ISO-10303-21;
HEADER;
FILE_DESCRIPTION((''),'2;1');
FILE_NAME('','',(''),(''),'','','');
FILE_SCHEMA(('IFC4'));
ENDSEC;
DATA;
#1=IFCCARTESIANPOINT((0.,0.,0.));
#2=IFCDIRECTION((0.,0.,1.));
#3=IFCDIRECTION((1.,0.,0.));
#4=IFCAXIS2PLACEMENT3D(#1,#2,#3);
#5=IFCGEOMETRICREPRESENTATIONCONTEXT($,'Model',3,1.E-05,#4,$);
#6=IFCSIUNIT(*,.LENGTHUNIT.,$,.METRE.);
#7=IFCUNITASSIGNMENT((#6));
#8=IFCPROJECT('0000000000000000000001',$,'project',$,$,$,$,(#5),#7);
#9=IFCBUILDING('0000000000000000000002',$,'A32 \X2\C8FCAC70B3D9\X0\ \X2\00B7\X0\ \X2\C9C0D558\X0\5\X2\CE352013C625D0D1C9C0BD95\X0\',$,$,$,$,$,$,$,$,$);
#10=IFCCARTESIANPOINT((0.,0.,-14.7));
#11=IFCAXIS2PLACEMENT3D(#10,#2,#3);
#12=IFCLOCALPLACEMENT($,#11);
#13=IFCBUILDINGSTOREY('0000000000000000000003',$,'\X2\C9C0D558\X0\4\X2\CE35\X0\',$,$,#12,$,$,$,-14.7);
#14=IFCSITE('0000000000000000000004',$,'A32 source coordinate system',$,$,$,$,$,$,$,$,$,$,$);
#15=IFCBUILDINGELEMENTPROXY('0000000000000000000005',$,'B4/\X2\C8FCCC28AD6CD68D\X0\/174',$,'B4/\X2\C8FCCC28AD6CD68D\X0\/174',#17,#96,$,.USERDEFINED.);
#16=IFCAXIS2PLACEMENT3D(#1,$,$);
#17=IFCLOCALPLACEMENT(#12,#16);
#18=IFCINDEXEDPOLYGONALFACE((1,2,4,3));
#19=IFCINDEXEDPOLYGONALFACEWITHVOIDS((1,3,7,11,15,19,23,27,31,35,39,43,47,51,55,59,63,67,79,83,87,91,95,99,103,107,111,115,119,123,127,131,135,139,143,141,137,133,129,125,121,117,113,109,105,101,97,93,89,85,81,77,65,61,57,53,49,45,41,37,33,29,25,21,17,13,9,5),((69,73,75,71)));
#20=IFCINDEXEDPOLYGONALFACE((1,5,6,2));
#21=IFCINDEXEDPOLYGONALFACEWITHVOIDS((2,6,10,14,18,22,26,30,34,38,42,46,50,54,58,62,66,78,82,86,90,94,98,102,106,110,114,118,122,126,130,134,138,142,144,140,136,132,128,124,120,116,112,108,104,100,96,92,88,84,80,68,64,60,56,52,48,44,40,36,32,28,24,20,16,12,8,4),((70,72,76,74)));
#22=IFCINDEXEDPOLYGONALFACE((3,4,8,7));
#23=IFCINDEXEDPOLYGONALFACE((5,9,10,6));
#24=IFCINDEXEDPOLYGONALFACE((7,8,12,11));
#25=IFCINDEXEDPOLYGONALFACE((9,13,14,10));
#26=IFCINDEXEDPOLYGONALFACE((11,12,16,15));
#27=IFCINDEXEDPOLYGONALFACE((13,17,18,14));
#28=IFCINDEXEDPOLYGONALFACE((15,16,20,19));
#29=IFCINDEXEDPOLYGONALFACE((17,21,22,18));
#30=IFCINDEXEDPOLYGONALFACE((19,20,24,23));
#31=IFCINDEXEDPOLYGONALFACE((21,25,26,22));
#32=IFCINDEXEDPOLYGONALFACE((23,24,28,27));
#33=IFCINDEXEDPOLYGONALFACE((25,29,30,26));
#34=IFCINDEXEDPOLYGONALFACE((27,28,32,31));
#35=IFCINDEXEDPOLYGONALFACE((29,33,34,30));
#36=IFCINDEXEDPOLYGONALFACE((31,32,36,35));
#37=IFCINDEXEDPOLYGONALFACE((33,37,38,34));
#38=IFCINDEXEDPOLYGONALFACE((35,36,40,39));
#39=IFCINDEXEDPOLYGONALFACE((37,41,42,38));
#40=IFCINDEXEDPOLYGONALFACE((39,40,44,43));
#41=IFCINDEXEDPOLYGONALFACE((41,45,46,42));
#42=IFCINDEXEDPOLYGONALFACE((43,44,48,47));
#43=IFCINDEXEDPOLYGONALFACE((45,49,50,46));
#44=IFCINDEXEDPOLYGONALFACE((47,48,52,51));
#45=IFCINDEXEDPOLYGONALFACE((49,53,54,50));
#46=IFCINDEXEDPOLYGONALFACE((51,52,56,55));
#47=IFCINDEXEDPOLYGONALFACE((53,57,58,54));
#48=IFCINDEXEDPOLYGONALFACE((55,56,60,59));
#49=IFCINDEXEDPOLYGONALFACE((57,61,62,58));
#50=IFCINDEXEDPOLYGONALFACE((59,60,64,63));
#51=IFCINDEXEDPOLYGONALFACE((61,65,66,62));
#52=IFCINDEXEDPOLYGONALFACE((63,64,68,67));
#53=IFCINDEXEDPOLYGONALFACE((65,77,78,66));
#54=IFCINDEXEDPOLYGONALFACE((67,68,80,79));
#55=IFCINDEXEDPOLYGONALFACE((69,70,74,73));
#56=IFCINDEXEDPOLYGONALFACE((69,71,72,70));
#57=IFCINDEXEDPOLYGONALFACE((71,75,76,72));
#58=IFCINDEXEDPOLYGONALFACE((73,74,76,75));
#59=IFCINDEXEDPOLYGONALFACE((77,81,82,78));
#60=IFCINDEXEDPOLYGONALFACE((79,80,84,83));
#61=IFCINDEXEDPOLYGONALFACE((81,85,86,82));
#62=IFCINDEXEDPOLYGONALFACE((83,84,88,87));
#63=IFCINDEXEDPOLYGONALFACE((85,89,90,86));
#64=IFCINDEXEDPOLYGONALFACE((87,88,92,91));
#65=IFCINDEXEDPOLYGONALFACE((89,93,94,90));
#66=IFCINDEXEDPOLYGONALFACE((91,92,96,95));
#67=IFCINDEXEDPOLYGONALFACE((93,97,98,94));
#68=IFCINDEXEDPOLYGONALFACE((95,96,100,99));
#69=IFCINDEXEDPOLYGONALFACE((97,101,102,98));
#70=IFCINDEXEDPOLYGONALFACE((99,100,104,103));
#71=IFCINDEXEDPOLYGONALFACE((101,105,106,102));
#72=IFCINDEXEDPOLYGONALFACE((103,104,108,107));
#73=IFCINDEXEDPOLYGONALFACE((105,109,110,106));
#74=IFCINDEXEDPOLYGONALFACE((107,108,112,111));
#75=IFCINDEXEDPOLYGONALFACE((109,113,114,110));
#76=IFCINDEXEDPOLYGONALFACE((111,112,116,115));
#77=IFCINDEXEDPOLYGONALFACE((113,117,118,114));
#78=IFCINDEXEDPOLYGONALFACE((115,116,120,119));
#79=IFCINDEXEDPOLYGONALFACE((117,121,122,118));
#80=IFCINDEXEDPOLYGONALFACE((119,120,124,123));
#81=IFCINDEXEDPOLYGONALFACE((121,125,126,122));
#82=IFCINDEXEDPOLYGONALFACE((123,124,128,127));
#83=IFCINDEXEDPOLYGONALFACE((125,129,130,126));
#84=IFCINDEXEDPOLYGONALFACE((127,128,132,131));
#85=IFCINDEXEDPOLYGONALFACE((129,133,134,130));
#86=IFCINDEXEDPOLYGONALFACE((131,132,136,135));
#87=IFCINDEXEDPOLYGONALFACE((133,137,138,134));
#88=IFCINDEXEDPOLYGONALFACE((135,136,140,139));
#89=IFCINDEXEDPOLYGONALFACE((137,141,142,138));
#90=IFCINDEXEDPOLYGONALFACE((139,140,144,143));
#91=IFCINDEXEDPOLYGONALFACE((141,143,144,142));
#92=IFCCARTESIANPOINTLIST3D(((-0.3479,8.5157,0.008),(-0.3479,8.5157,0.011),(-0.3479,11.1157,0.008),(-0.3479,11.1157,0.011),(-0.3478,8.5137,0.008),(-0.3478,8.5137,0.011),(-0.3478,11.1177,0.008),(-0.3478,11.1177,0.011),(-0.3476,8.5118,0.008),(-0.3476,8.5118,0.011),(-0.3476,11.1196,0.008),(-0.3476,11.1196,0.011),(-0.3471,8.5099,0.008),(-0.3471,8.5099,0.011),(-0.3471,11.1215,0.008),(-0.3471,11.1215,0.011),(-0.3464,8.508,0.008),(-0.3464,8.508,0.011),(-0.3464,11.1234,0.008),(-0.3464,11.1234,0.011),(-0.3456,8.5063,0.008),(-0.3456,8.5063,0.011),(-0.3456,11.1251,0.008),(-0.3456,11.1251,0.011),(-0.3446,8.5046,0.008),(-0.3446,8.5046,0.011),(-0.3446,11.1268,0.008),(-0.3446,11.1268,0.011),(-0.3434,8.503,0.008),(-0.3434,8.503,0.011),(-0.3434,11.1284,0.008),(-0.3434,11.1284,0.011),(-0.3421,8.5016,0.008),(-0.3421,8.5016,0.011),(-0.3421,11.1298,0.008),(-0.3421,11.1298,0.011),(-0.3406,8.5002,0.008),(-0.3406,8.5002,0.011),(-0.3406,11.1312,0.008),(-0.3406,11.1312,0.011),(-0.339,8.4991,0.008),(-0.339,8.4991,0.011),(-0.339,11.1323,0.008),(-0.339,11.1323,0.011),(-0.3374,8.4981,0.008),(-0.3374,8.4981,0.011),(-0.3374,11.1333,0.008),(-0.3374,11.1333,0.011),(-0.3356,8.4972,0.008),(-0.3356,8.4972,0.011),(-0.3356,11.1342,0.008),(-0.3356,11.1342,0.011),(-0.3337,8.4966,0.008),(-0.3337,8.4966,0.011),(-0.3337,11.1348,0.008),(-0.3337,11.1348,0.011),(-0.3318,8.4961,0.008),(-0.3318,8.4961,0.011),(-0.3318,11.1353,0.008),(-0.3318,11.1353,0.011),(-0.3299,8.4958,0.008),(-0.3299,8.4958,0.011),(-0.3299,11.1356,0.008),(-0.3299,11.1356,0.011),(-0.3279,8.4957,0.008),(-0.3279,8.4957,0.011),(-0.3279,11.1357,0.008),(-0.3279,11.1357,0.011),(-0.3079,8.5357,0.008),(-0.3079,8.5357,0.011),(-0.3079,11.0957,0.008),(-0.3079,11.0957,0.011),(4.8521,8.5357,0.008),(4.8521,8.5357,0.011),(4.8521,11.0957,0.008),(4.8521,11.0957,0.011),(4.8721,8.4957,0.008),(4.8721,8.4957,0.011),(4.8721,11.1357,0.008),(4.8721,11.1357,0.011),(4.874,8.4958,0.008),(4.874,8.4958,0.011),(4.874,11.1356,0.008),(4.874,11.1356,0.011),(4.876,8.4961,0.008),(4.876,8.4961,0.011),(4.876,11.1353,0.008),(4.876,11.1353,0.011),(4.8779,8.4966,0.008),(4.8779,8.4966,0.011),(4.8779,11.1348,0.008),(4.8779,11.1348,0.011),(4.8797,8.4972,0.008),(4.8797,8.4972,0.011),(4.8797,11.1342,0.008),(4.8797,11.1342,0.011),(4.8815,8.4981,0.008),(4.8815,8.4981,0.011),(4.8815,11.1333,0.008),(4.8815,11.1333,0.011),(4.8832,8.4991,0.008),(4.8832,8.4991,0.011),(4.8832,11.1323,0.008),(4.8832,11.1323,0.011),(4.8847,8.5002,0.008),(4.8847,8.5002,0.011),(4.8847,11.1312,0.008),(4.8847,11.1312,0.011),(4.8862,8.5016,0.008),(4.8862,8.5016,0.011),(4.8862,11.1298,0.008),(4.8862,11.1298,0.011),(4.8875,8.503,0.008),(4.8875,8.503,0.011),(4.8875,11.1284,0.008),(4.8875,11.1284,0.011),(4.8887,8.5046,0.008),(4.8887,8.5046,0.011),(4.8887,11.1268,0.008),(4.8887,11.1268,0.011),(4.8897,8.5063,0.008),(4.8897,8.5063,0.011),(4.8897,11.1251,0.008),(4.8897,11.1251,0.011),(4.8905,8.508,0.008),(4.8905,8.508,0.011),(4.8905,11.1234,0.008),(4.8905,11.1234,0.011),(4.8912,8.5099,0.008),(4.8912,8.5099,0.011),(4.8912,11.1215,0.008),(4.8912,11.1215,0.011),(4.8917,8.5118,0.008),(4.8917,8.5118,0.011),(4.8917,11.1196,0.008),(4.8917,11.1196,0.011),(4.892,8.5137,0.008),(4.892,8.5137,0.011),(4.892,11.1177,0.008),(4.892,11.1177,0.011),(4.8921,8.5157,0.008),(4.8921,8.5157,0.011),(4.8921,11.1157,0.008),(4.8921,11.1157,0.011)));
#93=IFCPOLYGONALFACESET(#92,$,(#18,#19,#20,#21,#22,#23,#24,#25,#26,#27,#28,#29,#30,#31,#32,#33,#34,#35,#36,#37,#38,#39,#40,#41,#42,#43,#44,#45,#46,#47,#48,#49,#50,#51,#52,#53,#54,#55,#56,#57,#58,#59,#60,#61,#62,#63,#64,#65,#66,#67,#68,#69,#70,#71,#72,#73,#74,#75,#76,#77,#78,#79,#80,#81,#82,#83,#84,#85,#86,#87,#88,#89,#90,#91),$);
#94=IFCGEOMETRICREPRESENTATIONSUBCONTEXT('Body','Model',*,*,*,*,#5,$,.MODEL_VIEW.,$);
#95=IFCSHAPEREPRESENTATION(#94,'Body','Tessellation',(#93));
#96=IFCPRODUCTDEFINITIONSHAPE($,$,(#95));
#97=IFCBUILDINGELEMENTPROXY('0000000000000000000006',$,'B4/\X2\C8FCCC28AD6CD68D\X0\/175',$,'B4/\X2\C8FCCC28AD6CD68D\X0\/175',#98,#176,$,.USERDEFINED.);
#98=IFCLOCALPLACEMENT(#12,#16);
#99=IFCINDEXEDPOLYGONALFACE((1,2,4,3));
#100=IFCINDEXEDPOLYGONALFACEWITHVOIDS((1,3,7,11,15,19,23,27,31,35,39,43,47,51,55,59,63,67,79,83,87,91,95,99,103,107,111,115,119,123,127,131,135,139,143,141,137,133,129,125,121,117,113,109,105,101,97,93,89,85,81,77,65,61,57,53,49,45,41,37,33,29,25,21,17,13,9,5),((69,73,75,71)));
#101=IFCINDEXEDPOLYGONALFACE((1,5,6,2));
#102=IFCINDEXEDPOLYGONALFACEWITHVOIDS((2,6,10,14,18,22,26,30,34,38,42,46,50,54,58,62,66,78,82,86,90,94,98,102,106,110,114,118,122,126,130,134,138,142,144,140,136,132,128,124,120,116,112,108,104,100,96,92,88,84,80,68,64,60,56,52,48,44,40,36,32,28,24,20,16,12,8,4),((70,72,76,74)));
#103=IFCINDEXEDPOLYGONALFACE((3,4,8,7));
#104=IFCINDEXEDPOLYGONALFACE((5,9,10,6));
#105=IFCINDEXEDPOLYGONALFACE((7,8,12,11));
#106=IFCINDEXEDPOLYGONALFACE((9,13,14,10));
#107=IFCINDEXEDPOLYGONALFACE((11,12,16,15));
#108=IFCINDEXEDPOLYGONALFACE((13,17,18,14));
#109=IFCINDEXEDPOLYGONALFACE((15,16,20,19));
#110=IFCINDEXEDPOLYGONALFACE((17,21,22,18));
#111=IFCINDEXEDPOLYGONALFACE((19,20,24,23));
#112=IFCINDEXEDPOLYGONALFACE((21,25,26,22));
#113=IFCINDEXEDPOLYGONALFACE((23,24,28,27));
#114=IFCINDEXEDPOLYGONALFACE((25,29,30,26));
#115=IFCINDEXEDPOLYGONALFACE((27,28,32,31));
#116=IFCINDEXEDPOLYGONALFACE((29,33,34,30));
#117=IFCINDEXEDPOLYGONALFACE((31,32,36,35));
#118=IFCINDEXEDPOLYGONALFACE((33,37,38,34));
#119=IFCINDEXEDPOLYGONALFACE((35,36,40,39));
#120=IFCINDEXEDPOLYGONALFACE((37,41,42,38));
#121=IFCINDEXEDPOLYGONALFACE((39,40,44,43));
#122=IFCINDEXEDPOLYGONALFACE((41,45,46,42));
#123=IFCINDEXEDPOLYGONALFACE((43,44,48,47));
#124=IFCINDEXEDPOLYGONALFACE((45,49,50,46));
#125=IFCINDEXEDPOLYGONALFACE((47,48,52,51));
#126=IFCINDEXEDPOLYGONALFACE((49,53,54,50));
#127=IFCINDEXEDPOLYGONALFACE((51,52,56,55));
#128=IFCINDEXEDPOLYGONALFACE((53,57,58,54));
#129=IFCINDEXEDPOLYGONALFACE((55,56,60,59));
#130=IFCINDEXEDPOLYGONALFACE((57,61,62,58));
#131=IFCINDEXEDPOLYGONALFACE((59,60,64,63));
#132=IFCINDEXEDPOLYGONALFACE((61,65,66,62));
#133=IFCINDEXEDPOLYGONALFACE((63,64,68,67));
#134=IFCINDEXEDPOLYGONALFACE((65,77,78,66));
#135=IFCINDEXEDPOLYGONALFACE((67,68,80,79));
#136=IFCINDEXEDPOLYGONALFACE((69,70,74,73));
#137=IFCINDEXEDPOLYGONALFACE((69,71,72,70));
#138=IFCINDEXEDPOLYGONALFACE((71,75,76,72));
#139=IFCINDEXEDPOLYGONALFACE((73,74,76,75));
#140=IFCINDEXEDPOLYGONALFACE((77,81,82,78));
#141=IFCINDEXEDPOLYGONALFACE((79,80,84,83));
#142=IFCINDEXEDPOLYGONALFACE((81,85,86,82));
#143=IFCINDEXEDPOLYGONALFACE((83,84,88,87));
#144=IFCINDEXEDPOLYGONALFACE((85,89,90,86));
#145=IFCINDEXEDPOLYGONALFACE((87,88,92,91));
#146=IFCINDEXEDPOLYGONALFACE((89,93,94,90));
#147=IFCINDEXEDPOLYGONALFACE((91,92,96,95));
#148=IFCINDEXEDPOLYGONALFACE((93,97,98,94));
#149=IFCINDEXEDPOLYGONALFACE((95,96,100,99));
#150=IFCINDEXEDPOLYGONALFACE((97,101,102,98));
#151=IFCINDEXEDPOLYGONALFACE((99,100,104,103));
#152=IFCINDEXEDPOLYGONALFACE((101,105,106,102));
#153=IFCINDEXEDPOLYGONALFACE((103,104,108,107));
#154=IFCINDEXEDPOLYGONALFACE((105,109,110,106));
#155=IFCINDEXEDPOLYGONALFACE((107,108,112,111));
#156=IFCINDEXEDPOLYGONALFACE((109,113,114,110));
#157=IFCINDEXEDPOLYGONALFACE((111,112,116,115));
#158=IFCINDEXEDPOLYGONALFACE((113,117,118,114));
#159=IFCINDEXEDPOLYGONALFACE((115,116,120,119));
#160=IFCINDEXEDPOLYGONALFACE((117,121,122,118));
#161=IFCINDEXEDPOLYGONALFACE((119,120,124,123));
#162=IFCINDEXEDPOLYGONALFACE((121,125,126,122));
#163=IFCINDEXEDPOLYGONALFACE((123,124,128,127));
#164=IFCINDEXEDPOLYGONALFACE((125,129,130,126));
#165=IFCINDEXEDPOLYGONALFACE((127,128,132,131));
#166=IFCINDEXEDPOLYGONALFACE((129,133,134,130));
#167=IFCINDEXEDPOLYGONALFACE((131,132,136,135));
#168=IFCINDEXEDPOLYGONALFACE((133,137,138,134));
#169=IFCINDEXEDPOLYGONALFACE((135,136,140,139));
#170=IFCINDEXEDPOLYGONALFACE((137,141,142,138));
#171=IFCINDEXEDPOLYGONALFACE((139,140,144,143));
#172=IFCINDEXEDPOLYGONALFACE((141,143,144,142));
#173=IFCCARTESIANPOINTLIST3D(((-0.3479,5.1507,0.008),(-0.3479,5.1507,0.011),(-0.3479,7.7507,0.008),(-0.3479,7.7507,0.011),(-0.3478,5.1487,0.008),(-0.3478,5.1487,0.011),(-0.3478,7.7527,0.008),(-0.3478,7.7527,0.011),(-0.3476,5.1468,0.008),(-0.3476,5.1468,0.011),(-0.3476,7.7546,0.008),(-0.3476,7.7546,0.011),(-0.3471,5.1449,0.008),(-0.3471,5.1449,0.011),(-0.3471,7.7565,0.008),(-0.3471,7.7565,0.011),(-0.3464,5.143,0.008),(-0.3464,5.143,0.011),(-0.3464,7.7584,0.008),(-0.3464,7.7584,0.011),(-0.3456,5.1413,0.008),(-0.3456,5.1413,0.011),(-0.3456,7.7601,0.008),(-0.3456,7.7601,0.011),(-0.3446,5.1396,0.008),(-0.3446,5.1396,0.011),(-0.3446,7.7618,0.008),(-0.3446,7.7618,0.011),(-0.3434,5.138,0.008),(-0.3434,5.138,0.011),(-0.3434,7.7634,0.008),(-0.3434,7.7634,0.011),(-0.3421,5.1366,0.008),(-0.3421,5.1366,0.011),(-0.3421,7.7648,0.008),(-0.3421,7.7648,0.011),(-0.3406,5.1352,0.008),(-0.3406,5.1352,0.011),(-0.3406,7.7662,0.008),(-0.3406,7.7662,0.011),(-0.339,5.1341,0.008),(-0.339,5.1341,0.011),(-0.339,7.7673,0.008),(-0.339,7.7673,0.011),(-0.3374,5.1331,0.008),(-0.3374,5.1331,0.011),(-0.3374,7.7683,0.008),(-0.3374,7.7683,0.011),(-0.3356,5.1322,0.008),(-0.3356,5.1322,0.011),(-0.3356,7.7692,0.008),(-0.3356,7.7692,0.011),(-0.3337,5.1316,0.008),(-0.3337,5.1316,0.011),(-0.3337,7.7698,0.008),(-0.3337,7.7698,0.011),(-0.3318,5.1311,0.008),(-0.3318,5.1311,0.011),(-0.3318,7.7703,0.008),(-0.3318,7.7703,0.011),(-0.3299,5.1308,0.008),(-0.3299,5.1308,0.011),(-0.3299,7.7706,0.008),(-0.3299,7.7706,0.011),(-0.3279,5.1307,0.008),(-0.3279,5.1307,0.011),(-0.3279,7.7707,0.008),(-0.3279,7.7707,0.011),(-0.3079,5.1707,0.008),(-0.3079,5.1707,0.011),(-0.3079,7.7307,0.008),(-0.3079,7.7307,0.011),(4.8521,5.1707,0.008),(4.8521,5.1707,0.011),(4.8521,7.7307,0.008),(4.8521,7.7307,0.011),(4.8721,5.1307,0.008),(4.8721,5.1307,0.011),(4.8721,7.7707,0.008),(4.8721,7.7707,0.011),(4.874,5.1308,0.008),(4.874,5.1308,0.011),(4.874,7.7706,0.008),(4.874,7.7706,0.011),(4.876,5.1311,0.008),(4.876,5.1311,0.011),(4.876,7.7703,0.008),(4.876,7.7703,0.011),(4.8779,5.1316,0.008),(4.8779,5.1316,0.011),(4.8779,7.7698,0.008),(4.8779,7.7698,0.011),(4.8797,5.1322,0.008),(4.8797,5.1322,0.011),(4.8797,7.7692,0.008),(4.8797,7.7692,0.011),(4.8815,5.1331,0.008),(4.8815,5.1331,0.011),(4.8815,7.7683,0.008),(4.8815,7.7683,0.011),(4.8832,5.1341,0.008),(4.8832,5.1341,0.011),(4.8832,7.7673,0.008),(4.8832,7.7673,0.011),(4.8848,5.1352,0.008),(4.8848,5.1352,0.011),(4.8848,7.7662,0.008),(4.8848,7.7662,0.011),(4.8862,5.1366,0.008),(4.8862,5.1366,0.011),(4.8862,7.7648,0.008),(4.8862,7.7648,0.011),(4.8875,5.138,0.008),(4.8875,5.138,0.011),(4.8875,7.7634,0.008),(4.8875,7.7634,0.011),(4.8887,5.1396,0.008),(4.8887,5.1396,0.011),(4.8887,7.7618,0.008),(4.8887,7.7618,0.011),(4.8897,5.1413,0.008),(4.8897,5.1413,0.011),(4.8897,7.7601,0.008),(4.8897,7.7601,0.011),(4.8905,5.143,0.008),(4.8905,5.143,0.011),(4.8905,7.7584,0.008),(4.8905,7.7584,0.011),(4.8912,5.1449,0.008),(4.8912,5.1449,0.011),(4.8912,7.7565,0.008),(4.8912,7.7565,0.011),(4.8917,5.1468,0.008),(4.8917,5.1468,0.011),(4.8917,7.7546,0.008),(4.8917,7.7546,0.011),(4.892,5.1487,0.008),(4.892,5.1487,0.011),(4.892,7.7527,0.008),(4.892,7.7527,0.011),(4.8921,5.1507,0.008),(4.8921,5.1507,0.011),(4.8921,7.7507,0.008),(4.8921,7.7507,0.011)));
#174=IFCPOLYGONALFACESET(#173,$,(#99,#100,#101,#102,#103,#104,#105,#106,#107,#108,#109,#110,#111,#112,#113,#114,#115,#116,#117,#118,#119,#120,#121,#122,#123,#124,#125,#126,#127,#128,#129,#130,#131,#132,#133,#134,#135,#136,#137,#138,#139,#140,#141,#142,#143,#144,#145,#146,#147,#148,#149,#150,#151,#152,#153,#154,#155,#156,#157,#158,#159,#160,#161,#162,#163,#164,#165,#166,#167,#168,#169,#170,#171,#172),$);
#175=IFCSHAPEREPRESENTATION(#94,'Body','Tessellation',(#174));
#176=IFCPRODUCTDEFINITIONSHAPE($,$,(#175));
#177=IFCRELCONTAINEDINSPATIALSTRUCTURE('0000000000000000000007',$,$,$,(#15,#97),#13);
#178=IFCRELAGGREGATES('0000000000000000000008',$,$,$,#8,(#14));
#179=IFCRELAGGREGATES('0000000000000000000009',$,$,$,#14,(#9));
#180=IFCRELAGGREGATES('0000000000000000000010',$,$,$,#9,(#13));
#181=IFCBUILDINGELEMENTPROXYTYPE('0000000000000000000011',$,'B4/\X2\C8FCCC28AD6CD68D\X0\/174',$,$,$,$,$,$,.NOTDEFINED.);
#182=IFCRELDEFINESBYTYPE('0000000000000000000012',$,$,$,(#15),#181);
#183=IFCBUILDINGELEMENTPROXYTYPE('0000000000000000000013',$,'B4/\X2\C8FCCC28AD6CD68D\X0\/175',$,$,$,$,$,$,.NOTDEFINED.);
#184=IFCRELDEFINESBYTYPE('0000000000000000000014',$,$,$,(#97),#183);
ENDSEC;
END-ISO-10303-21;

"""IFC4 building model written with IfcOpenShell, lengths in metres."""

from ifc_helpers import new_model, si_unit, frame, origin, origin_with_axes, place, context, subcontext, project, spatial, polyline, outline, extrude, source, transform, mapped, type_object, type_shapes, element, save


model = new_model("IFC4")

# Units and contexts
model_context = context("Model", 3, precision=1e-05, world=origin_with_axes())
body_context = subcontext(model_context, "Body", "Model", "MODEL_VIEW")
ifc_project = project(units=[si_unit("LENGTHUNIT", "METRE")], contexts=[model_context])

# Site, building, storey
site = spatial("IfcSite", under=ifc_project, Name="A32 source coordinate system")
building = spatial("IfcBuilding", under=site, Name="A32 주거동 · 지하5층–옥탑지붕")
storey_placement = place(None, frame((0.0, 0.0, -14.7), z_axis=(0.0, 0.0, 1.0), x_axis=(1.0, 0.0, 0.0)))
storey = spatial("IfcBuildingStorey", under=building, at=storey_placement, Name="지하4층", Elevation=-14.7)

# Building element proxies
building_element_proxy_type_1 = type_object("IfcBuildingElementProxyType", Name="B4/주차구획/174", PredefinedType="NOTDEFINED")
shared_shape_1 = source(origin(), body_context, "Body", "SweptSolid", [
    extrude(outline(polyline([(-0.3279, 8.4957), (-0.3299, 8.4958), (-0.3318, 8.4961), (-0.3337, 8.4966), (-0.3356, 8.4972), (-0.3374, 8.4981), (-0.339, 8.4991), (-0.3406, 8.5002), (-0.3421, 8.5016), (-0.3434, 8.503), (-0.3446, 8.5046), (-0.3456, 8.5063), (-0.3464, 8.508), (-0.3471, 8.5099), (-0.3476, 8.5118), (-0.3478, 8.5137), (-0.3479, 8.5157), (-0.3479, 11.1157), (-0.3478, 11.1177), (-0.3476, 11.1196), (-0.3471, 11.1215), (-0.3464, 11.1234), (-0.3456, 11.1251), (-0.3446, 11.1268), (-0.3434, 11.1284), (-0.3421, 11.1298), (-0.3406, 11.1312), (-0.339, 11.1323), (-0.3374, 11.1333), (-0.3356, 11.1342), (-0.3337, 11.1348), (-0.3318, 11.1353), (-0.3299, 11.1356), (-0.3279, 11.1357), (4.8721, 11.1357), (4.874, 11.1356), (4.876, 11.1353), (4.8779, 11.1348), (4.8797, 11.1342), (4.8815, 11.1333), (4.8832, 11.1323), (4.8847, 11.1312), (4.8862, 11.1298), (4.8875, 11.1284), (4.8887, 11.1268), (4.8897, 11.1251), (4.8905, 11.1234), (4.8912, 11.1215), (4.8917, 11.1196), (4.892, 11.1177), (4.8921, 11.1157), (4.8921, 8.5157), (4.892, 8.5137), (4.8917, 8.5118), (4.8912, 8.5099), (4.8905, 8.508), (4.8897, 8.5063), (4.8887, 8.5046), (4.8875, 8.503), (4.8862, 8.5016), (4.8847, 8.5002), (4.8832, 8.4991), (4.8815, 8.4981), (4.8797, 8.4972), (4.8779, 8.4966), (4.876, 8.4961), (4.874, 8.4958), (4.8721, 8.4957), (-0.3279, 8.4957)]), holes=[polyline([(-0.3079, 8.5357), (4.8521, 8.5357), (4.8521, 11.0957), (-0.3079, 11.0957), (-0.3079, 8.5357)])]), frame((0.0, 0.0, 0.008)), (0.0, 0.0, 1.0), 0.003),
])
type_shapes(building_element_proxy_type_1, [shared_shape_1])
proxy_1_placement = place(storey_placement, origin_with_axes())
element("IfcBuildingElementProxy", 1, at=proxy_1_placement, inside=storey, type_object=building_element_proxy_type_1, Name="B4/주차구획/174", ObjectType="B4/주차구획/174", PredefinedType="USERDEFINED", context=body_context, shape_type="MappedRepresentation", body=[
    mapped(shared_shape_1, transform((0.0, 0.0, 0.0), scale=1.0)),
])
building_element_proxy_type_2 = type_object("IfcBuildingElementProxyType", Name="B4/주차구획/175", PredefinedType="NOTDEFINED")
shared_shape_2 = source(origin(), body_context, "Body", "SweptSolid", [
    extrude(outline(polyline([(-0.3279, 5.1307), (-0.3299, 5.1308), (-0.3318, 5.1311), (-0.3337, 5.1316), (-0.3356, 5.1322), (-0.3374, 5.1331), (-0.339, 5.1341), (-0.3406, 5.1352), (-0.3421, 5.1366), (-0.3434, 5.138), (-0.3446, 5.1396), (-0.3456, 5.1413), (-0.3464, 5.143), (-0.3471, 5.1449), (-0.3476, 5.1468), (-0.3478, 5.1487), (-0.3479, 5.1507), (-0.3479, 7.7507), (-0.3478, 7.7527), (-0.3476, 7.7546), (-0.3471, 7.7565), (-0.3464, 7.7584), (-0.3456, 7.7601), (-0.3446, 7.7618), (-0.3434, 7.7634), (-0.3421, 7.7648), (-0.3406, 7.7662), (-0.339, 7.7673), (-0.3374, 7.7683), (-0.3356, 7.7692), (-0.3337, 7.7698), (-0.3318, 7.7703), (-0.3299, 7.7706), (-0.3279, 7.7707), (4.8721, 7.7707), (4.874, 7.7706), (4.876, 7.7703), (4.8779, 7.7698), (4.8797, 7.7692), (4.8815, 7.7683), (4.8832, 7.7673), (4.8848, 7.7662), (4.8862, 7.7648), (4.8875, 7.7634), (4.8887, 7.7618), (4.8897, 7.7601), (4.8905, 7.7584), (4.8912, 7.7565), (4.8917, 7.7546), (4.892, 7.7527), (4.8921, 7.7507), (4.8921, 5.1507), (4.892, 5.1487), (4.8917, 5.1468), (4.8912, 5.1449), (4.8905, 5.143), (4.8897, 5.1413), (4.8887, 5.1396), (4.8875, 5.138), (4.8862, 5.1366), (4.8848, 5.1352), (4.8832, 5.1341), (4.8815, 5.1331), (4.8797, 5.1322), (4.8779, 5.1316), (4.876, 5.1311), (4.874, 5.1308), (4.8721, 5.1307), (-0.3279, 5.1307)]), holes=[polyline([(-0.3079, 5.1707), (4.8521, 5.1707), (4.8521, 7.7307), (-0.3079, 7.7307), (-0.3079, 5.1707)])]), frame((0.0, 0.0, 0.008)), (0.0, 0.0, 1.0), 0.003),
])
type_shapes(building_element_proxy_type_2, [shared_shape_2])
proxy_2_placement = place(storey_placement, origin_with_axes())
element("IfcBuildingElementProxy", 2, at=proxy_2_placement, inside=storey, type_object=building_element_proxy_type_2, Name="B4/주차구획/175", ObjectType="B4/주차구획/175", PredefinedType="USERDEFINED", context=body_context, shape_type="MappedRepresentation", body=[
    mapped(shared_shape_2, transform((0.0, 0.0, 0.0), scale=1.0)),
])

save(model, "model.ifc")
